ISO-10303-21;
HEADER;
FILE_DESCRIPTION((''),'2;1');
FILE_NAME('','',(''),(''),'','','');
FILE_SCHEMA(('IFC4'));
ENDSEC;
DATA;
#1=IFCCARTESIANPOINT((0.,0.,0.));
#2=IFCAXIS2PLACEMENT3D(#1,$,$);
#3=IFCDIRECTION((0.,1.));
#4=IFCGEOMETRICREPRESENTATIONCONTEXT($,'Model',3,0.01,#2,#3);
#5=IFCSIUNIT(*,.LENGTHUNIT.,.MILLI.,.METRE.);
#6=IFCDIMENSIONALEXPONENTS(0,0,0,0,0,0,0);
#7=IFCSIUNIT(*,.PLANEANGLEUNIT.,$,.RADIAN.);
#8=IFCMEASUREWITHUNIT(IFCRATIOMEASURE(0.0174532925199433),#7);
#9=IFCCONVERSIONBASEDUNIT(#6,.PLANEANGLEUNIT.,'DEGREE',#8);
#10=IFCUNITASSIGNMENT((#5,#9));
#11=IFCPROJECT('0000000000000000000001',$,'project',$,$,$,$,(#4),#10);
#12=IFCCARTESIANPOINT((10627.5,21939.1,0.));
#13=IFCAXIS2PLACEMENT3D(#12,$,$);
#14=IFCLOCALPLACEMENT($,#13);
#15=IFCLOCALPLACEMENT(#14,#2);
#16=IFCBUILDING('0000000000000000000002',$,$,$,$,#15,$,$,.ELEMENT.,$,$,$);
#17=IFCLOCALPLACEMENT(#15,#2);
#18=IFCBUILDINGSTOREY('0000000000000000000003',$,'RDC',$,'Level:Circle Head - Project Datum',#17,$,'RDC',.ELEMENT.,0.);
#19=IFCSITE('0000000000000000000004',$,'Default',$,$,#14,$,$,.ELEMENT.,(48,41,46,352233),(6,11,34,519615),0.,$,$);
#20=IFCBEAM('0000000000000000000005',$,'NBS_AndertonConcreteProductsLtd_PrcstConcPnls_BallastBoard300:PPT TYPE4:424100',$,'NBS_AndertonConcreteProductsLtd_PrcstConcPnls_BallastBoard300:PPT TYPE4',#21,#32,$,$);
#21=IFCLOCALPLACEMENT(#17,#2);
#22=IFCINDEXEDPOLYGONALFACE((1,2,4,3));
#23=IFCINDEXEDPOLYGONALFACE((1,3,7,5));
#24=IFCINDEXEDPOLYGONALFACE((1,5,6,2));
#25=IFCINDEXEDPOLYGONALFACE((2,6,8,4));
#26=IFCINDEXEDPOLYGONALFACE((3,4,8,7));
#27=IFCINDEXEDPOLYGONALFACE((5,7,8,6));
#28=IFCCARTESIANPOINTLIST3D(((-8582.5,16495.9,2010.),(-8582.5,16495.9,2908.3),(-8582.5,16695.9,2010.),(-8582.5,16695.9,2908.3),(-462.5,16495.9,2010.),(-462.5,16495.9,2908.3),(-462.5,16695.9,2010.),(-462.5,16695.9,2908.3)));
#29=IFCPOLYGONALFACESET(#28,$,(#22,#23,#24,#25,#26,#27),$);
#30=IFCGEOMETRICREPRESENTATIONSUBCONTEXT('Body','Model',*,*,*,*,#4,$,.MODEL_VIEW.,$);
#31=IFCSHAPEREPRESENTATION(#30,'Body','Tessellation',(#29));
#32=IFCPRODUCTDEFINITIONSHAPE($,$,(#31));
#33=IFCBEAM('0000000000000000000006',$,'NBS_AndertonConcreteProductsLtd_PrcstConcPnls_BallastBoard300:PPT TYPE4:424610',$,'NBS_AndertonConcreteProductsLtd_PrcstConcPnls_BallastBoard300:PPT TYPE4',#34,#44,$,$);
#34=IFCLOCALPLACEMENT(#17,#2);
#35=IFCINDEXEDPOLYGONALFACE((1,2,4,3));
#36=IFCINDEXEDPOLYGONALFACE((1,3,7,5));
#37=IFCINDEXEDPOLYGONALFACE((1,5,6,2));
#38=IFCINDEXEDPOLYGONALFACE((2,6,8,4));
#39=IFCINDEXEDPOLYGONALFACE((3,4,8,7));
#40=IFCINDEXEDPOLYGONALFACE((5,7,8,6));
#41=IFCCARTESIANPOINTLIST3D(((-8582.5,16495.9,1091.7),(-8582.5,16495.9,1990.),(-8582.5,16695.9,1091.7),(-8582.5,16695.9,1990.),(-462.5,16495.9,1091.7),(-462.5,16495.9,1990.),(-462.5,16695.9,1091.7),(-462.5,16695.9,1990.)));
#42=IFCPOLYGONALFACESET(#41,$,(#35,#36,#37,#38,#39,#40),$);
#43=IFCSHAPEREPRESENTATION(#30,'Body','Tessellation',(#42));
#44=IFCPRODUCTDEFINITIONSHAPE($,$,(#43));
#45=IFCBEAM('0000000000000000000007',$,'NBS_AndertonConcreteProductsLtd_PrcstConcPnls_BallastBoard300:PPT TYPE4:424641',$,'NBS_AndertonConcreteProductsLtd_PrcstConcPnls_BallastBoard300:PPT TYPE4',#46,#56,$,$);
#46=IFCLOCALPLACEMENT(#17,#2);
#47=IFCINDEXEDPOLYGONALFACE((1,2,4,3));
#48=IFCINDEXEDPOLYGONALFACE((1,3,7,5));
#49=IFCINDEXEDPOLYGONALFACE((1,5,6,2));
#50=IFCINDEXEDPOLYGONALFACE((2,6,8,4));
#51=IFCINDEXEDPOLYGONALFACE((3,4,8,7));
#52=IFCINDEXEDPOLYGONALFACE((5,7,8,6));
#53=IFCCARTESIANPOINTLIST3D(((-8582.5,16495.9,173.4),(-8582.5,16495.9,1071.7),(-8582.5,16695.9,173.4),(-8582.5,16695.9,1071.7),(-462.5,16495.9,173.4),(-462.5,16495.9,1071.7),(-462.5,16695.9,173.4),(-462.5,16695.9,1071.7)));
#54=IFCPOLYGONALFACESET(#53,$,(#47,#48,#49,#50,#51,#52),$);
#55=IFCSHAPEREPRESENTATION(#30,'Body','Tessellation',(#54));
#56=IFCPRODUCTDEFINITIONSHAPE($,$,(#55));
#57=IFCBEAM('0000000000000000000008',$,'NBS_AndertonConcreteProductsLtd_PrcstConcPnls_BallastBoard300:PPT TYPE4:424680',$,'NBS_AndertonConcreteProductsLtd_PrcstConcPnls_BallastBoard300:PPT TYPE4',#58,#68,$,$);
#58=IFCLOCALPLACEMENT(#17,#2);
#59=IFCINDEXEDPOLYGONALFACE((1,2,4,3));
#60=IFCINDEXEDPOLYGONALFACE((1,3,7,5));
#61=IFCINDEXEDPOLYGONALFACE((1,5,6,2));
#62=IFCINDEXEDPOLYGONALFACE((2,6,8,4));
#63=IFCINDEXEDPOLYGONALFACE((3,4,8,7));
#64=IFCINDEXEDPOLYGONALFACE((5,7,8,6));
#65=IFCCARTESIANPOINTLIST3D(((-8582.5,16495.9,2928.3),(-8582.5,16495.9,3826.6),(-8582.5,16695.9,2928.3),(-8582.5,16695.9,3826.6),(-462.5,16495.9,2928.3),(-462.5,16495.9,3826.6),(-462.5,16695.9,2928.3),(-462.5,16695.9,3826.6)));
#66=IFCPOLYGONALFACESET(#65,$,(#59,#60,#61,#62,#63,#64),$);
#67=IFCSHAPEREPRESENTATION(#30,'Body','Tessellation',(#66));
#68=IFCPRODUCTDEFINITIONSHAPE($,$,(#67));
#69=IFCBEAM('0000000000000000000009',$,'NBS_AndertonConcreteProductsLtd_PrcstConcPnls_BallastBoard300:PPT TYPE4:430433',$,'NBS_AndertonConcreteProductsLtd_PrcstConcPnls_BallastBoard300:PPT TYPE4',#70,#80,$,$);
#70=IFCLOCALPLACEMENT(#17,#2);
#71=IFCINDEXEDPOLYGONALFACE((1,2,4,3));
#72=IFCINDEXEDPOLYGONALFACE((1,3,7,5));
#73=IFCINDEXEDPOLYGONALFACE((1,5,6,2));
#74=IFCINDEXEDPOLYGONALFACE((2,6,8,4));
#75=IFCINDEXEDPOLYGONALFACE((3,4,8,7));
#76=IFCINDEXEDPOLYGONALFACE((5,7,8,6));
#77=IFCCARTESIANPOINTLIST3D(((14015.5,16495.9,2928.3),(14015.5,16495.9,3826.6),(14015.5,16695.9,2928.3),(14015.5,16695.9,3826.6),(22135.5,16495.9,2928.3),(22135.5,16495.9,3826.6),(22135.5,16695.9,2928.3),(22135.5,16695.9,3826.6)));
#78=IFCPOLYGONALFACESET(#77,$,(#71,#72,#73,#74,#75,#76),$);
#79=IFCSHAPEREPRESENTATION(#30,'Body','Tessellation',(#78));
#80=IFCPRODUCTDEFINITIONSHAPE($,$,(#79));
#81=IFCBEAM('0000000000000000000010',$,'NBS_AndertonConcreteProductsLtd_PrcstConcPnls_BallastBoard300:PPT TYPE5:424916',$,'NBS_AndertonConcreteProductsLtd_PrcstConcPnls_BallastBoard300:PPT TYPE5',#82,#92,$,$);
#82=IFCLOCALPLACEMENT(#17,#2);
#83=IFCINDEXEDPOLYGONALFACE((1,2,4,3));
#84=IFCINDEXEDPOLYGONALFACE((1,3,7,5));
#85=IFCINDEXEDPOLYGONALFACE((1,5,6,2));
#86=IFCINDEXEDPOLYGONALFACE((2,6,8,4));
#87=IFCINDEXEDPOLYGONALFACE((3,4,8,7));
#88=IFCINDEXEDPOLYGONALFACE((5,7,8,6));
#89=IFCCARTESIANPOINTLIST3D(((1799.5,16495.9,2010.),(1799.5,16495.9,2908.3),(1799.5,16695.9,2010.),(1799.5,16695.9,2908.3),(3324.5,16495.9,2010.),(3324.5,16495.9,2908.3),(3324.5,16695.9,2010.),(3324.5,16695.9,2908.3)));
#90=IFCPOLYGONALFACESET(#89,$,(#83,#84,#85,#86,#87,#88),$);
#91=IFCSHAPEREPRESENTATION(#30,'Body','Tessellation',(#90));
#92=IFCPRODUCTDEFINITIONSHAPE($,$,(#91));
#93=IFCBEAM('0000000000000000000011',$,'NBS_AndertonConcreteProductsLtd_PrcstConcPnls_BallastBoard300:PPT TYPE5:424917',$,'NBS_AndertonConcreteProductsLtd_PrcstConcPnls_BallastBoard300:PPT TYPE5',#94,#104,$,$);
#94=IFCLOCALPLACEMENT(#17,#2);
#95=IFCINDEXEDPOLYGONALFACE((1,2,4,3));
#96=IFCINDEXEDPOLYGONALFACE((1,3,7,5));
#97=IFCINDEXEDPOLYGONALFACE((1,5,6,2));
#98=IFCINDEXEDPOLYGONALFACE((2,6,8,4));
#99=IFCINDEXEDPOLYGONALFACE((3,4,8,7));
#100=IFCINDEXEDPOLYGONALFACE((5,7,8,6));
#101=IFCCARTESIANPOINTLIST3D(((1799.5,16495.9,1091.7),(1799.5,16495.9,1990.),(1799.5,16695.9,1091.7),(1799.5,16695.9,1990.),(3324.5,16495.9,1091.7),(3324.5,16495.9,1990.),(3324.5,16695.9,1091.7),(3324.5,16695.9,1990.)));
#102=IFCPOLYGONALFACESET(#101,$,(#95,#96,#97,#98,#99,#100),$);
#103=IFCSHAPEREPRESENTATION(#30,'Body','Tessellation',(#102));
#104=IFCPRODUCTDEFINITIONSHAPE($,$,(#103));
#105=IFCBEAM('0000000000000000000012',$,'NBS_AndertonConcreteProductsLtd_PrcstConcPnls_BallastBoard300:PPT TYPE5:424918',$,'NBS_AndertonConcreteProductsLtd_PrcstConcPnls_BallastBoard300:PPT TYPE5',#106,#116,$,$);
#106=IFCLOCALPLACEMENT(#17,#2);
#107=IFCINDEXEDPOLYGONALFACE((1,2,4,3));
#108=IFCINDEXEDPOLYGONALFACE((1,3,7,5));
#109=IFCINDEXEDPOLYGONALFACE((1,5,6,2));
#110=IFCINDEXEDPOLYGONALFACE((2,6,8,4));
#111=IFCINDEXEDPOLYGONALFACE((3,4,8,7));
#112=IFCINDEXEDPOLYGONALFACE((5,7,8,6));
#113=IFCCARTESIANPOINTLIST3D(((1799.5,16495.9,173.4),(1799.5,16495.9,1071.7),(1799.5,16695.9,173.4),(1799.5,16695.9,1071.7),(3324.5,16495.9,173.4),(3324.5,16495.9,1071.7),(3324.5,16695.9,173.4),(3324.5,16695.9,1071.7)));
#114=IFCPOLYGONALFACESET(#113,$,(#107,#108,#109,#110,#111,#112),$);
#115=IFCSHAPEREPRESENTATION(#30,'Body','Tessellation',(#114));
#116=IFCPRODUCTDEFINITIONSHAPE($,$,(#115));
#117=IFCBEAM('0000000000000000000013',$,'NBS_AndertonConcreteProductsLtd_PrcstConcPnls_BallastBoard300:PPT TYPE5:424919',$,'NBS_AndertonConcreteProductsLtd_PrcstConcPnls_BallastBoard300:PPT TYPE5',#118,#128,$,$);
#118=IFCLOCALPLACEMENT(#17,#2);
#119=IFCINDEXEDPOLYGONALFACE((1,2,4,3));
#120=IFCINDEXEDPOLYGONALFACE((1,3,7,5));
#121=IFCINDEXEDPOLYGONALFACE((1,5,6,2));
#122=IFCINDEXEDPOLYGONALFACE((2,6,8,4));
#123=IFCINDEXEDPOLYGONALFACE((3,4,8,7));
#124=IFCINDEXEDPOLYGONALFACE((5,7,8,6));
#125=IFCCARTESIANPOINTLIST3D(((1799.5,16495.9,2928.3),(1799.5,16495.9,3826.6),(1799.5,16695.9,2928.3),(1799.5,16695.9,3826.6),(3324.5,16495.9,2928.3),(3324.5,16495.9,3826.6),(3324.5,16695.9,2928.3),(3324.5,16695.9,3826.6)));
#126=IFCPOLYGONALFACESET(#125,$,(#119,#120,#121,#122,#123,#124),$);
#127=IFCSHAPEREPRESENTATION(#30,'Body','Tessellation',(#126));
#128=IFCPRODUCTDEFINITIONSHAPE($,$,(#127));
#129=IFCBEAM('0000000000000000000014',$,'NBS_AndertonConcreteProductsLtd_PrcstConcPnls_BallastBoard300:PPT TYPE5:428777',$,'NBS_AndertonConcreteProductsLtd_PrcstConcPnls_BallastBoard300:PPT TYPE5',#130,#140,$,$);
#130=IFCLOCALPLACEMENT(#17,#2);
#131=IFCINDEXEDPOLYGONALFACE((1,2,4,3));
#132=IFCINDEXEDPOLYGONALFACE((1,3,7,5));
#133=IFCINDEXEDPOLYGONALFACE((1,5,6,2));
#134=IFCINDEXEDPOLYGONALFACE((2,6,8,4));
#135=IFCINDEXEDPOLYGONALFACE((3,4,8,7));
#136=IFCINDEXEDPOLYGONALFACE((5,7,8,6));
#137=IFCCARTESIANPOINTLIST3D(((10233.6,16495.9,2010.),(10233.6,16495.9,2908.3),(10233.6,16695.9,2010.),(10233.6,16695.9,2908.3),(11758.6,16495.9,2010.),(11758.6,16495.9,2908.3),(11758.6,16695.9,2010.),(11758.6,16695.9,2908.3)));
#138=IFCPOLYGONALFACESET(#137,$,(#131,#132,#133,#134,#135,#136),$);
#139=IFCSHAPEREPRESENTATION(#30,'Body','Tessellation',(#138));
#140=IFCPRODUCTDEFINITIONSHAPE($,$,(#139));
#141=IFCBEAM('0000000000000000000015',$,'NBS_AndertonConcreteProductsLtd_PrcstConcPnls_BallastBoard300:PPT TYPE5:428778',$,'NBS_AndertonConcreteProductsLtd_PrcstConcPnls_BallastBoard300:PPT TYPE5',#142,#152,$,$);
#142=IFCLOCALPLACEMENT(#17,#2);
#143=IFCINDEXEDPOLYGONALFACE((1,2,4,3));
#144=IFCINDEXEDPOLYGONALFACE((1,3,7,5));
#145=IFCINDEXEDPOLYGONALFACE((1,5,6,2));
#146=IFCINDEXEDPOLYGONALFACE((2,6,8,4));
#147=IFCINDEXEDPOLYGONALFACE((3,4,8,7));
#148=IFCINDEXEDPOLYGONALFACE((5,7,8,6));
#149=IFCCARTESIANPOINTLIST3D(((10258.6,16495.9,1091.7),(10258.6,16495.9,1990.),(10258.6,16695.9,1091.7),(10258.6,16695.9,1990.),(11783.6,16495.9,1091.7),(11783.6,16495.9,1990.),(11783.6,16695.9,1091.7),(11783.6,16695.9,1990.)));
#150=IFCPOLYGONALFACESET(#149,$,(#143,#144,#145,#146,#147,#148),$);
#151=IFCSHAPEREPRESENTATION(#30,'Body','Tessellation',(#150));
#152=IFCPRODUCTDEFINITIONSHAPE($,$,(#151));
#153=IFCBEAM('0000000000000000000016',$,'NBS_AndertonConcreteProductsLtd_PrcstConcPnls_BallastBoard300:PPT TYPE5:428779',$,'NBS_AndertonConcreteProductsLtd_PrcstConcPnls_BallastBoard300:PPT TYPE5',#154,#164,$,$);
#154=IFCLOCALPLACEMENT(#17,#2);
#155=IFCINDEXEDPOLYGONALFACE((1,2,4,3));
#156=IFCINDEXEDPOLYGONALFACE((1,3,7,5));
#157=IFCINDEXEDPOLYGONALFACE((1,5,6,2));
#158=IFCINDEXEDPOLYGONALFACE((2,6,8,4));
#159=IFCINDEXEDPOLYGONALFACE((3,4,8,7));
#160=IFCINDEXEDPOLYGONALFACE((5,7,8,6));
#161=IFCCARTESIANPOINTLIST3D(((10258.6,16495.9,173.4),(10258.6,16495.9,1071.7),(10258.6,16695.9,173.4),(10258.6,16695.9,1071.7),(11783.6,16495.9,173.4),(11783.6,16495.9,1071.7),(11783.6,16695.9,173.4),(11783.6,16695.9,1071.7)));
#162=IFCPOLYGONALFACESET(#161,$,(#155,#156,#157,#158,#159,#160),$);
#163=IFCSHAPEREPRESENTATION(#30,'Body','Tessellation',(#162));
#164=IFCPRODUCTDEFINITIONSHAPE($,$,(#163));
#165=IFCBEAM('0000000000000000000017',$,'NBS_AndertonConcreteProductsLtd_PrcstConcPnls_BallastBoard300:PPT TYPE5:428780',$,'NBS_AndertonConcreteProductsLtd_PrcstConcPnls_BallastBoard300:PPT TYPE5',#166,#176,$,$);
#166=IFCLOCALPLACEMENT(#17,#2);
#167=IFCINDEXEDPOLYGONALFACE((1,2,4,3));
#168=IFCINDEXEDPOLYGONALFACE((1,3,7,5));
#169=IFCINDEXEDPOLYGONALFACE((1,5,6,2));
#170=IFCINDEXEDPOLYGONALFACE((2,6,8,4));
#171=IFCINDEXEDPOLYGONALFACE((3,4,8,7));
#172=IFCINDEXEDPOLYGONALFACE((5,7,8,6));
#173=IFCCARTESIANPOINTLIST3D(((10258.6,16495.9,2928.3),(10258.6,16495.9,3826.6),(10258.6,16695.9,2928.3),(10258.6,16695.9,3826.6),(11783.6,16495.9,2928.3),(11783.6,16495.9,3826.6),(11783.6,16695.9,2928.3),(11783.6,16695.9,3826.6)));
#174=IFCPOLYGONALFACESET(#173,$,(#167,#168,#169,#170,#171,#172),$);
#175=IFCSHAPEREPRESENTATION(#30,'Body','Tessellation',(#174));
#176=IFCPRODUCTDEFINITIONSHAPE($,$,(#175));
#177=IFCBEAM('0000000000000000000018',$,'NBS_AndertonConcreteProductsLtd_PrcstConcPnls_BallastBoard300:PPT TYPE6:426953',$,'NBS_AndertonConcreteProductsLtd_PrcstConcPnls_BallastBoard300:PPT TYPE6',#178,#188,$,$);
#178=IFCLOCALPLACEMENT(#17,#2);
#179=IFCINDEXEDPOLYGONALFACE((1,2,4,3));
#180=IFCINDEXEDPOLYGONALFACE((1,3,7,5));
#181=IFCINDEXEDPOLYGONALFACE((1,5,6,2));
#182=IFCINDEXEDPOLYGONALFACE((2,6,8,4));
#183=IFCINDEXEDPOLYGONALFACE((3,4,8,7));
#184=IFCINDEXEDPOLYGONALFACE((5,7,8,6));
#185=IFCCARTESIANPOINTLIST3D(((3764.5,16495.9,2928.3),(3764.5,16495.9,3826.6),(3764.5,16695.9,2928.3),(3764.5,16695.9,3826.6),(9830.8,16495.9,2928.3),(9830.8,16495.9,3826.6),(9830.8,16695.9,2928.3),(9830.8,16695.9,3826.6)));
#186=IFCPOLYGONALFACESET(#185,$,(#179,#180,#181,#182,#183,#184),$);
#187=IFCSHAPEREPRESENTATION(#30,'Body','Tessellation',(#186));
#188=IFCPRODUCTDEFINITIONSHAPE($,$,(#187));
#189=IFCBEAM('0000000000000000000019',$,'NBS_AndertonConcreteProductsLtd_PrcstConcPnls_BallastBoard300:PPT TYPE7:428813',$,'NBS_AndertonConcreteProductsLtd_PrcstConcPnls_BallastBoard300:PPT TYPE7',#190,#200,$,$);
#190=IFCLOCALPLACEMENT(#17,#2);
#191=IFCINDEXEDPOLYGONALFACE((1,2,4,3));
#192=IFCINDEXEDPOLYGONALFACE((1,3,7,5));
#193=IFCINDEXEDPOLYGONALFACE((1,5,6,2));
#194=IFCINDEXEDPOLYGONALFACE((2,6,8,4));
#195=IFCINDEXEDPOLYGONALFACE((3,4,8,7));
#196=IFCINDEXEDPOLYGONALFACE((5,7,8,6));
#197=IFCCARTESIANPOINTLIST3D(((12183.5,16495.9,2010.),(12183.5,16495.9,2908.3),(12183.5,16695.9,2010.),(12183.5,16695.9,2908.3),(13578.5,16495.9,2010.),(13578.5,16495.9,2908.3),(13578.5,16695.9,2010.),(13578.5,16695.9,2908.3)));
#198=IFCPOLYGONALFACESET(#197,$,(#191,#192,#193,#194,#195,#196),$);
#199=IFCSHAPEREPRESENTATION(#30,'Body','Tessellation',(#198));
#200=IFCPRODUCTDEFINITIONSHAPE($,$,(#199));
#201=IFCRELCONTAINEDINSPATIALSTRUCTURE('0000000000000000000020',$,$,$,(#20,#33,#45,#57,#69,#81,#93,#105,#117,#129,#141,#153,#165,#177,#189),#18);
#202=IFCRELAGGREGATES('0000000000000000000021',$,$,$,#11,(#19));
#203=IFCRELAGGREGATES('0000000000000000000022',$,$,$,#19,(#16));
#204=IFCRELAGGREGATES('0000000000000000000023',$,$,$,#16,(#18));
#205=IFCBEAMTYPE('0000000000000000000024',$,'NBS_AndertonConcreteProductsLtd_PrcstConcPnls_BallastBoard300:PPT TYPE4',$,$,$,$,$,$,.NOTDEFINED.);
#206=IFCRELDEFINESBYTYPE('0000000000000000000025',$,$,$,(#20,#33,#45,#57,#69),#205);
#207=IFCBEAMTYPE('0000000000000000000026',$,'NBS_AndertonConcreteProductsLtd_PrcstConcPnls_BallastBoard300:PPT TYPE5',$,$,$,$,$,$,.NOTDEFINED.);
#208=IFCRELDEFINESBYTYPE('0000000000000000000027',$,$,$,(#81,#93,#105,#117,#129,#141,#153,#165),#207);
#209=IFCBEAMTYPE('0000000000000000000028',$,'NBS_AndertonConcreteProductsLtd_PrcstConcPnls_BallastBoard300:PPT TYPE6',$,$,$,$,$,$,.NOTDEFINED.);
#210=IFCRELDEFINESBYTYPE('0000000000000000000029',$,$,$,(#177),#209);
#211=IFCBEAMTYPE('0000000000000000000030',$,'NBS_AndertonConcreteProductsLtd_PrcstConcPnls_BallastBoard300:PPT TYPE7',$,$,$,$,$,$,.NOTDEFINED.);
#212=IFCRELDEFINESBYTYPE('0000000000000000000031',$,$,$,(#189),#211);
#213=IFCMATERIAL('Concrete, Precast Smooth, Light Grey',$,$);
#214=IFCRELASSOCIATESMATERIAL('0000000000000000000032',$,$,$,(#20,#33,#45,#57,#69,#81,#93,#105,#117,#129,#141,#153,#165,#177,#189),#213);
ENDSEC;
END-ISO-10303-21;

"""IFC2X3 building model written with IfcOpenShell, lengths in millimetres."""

from ifc_helpers import new_model, entity, si_unit, converted_unit, direction, frame, frame_2d, origin, place, context, subcontext, project, spatial, rectangle, extrude, material, type_object, element, save


model = new_model("IFC2X3")

# Units and contexts
model_context = context("Model", 3, precision=0.01, world=origin(), true_north=direction((0.0, 1.0)))
body_context = subcontext(model_context, "Body", "Model", "MODEL_VIEW")
ifc_project = project(units=[si_unit("LENGTHUNIT", "METRE", prefix="MILLI"), converted_unit("PLANEANGLEUNIT", "DEGREE", entity("IfcRatioMeasure", 0.0174532925199433), si_unit("PLANEANGLEUNIT", "RADIAN"), dimensions=[0, 0, 0, 0, 0, 0, 0])], contexts=[model_context])

# Site, building, storey
site_placement = place(None, frame((10627.5, 21939.1, 0.0)))
site = spatial("IfcSite", under=ifc_project, at=site_placement, Name="Default", CompositionType="ELEMENT", RefLatitude=(48, 41, 46, 352233), RefLongitude=(6, 11, 34, 519615), RefElevation=0.0)
building_placement = place(site_placement, origin())
building = spatial("IfcBuilding", under=site, at=building_placement, CompositionType="ELEMENT")
storey_placement = place(building_placement, origin())
storey = spatial("IfcBuildingStorey", under=building, at=storey_placement, Name="RDC", ObjectType="Level:Circle Head - Project Datum", LongName="RDC", CompositionType="ELEMENT", Elevation=0.0)

# Beams
ifc_material_1 = material(Name="Concrete, Precast Smooth, Light Grey")
beam_type_1 = type_object("IfcBeamType", Name="NBS_AndertonConcreteProductsLtd_PrcstConcPnls_BallastBoard300:PPT TYPE4", PredefinedType="NOTDEFINED")
beam_1_placement = place(storey_placement, origin())
element("IfcBeam", 1, at=beam_1_placement, inside=storey, type_object=beam_type_1, material=ifc_material_1, Name="NBS_AndertonConcreteProductsLtd_PrcstConcPnls_BallastBoard300:PPT TYPE4:424100", ObjectType="NBS_AndertonConcreteProductsLtd_PrcstConcPnls_BallastBoard300:PPT TYPE4", context=body_context, shape_type="SweptSolid", body=[
    extrude(rectangle(XDim=898.3, YDim=200.0, at=frame_2d((0.0, 0.0), x_axis=(0.0, 1.0))), frame((-8582.5, 16595.9, 2459.2), z_axis=(1.0, 0.0, 0.0), x_axis=(0.0, 1.0, 0.0)), (0.0, 0.0, 1.0), 8120.0),
])
beam_2_placement = place(storey_placement, origin())
element("IfcBeam", 2, at=beam_2_placement, inside=storey, type_object=beam_type_1, material=ifc_material_1, Name="NBS_AndertonConcreteProductsLtd_PrcstConcPnls_BallastBoard300:PPT TYPE4:424610", ObjectType="NBS_AndertonConcreteProductsLtd_PrcstConcPnls_BallastBoard300:PPT TYPE4", context=body_context, shape_type="SweptSolid", body=[
    extrude(rectangle(XDim=898.3, YDim=200.0, at=frame_2d((0.0, 0.0), x_axis=(0.0, 1.0))), frame((-8582.5, 16595.9, 1540.8), z_axis=(1.0, 0.0, 0.0), x_axis=(0.0, 1.0, 0.0)), (0.0, 0.0, 1.0), 8120.0),
])
beam_3_placement = place(storey_placement, origin())
element("IfcBeam", 3, at=beam_3_placement, inside=storey, type_object=beam_type_1, material=ifc_material_1, Name="NBS_AndertonConcreteProductsLtd_PrcstConcPnls_BallastBoard300:PPT TYPE4:424641", ObjectType="NBS_AndertonConcreteProductsLtd_PrcstConcPnls_BallastBoard300:PPT TYPE4", context=body_context, shape_type="SweptSolid", body=[
    extrude(rectangle(XDim=898.3, YDim=200.0, at=frame_2d((0.0, 0.0), x_axis=(0.0, 1.0))), frame((-8582.5, 16595.9, 622.5), z_axis=(1.0, 0.0, 0.0), x_axis=(0.0, 1.0, 0.0)), (0.0, 0.0, 1.0), 8120.0),
])
beam_4_placement = place(storey_placement, origin())
element("IfcBeam", 4, at=beam_4_placement, inside=storey, type_object=beam_type_1, material=ifc_material_1, Name="NBS_AndertonConcreteProductsLtd_PrcstConcPnls_BallastBoard300:PPT TYPE4:424680", ObjectType="NBS_AndertonConcreteProductsLtd_PrcstConcPnls_BallastBoard300:PPT TYPE4", context=body_context, shape_type="SweptSolid", body=[
    extrude(rectangle(XDim=898.3, YDim=200.0, at=frame_2d((0.0, 0.0), x_axis=(0.0, 1.0))), frame((-8582.5, 16595.9, 3377.5), z_axis=(1.0, 0.0, 0.0), x_axis=(0.0, 1.0, 0.0)), (0.0, 0.0, 1.0), 8120.0),
])
beam_5_placement = place(storey_placement, origin())
element("IfcBeam", 5, at=beam_5_placement, inside=storey, type_object=beam_type_1, material=ifc_material_1, Name="NBS_AndertonConcreteProductsLtd_PrcstConcPnls_BallastBoard300:PPT TYPE4:430433", ObjectType="NBS_AndertonConcreteProductsLtd_PrcstConcPnls_BallastBoard300:PPT TYPE4", context=body_context, shape_type="SweptSolid", body=[
    extrude(rectangle(XDim=898.3, YDim=200.0, at=frame_2d((0.0, 0.0), x_axis=(0.0, 1.0))), frame((14015.5, 16595.9, 3377.5), z_axis=(1.0, 0.0, 0.0), x_axis=(0.0, 1.0, 0.0)), (0.0, 0.0, 1.0), 8120.0),
])
beam_type_2 = type_object("IfcBeamType", Name="NBS_AndertonConcreteProductsLtd_PrcstConcPnls_BallastBoard300:PPT TYPE5", PredefinedType="NOTDEFINED")
beam_6_placement = place(storey_placement, origin())
element("IfcBeam", 6, at=beam_6_placement, inside=storey, type_object=beam_type_2, material=ifc_material_1, Name="NBS_AndertonConcreteProductsLtd_PrcstConcPnls_BallastBoard300:PPT TYPE5:424916", ObjectType="NBS_AndertonConcreteProductsLtd_PrcstConcPnls_BallastBoard300:PPT TYPE5", context=body_context, shape_type="SweptSolid", body=[
    extrude(rectangle(XDim=898.3, YDim=200.0, at=frame_2d((0.0, 0.0), x_axis=(0.0, 1.0))), frame((1799.5, 16595.9, 2459.2), z_axis=(1.0, 0.0, 0.0), x_axis=(0.0, 1.0, 0.0)), (0.0, 0.0, 1.0), 1525.0),
])
beam_7_placement = place(storey_placement, origin())
element("IfcBeam", 7, at=beam_7_placement, inside=storey, type_object=beam_type_2, material=ifc_material_1, Name="NBS_AndertonConcreteProductsLtd_PrcstConcPnls_BallastBoard300:PPT TYPE5:424917", ObjectType="NBS_AndertonConcreteProductsLtd_PrcstConcPnls_BallastBoard300:PPT TYPE5", context=body_context, shape_type="SweptSolid", body=[
    extrude(rectangle(XDim=898.3, YDim=200.0, at=frame_2d((0.0, 0.0), x_axis=(0.0, 1.0))), frame((1799.5, 16595.9, 1540.8), z_axis=(1.0, 0.0, 0.0), x_axis=(0.0, 1.0, 0.0)), (0.0, 0.0, 1.0), 1525.0),
])
beam_8_placement = place(storey_placement, origin())
element("IfcBeam", 8, at=beam_8_placement, inside=storey, type_object=beam_type_2, material=ifc_material_1, Name="NBS_AndertonConcreteProductsLtd_PrcstConcPnls_BallastBoard300:PPT TYPE5:424918", ObjectType="NBS_AndertonConcreteProductsLtd_PrcstConcPnls_BallastBoard300:PPT TYPE5", context=body_context, shape_type="SweptSolid", body=[
    extrude(rectangle(XDim=898.3, YDim=200.0, at=frame_2d((0.0, 0.0), x_axis=(0.0, 1.0))), frame((1799.5, 16595.9, 622.5), z_axis=(1.0, 0.0, 0.0), x_axis=(0.0, 1.0, 0.0)), (0.0, 0.0, 1.0), 1525.0),
])
beam_9_placement = place(storey_placement, origin())
element("IfcBeam", 9, at=beam_9_placement, inside=storey, type_object=beam_type_2, material=ifc_material_1, Name="NBS_AndertonConcreteProductsLtd_PrcstConcPnls_BallastBoard300:PPT TYPE5:424919", ObjectType="NBS_AndertonConcreteProductsLtd_PrcstConcPnls_BallastBoard300:PPT TYPE5", context=body_context, shape_type="SweptSolid", body=[
    extrude(rectangle(XDim=898.3, YDim=200.0, at=frame_2d((0.0, 0.0), x_axis=(0.0, 1.0))), frame((1799.5, 16595.9, 3377.5), z_axis=(1.0, 0.0, 0.0), x_axis=(0.0, 1.0, 0.0)), (0.0, 0.0, 1.0), 1525.0),
])
beam_10_placement = place(storey_placement, origin())
element("IfcBeam", 10, at=beam_10_placement, inside=storey, type_object=beam_type_2, material=ifc_material_1, Name="NBS_AndertonConcreteProductsLtd_PrcstConcPnls_BallastBoard300:PPT TYPE5:428777", ObjectType="NBS_AndertonConcreteProductsLtd_PrcstConcPnls_BallastBoard300:PPT TYPE5", context=body_context, shape_type="SweptSolid", body=[
    extrude(rectangle(XDim=898.3, YDim=200.0, at=frame_2d((0.0, 0.0), x_axis=(0.0, 1.0))), frame((10233.6, 16595.9, 2459.2), z_axis=(1.0, 0.0, 0.0), x_axis=(0.0, 1.0, 0.0)), (0.0, 0.0, 1.0), 1525.0),
])
beam_11_placement = place(storey_placement, origin())
element("IfcBeam", 11, at=beam_11_placement, inside=storey, type_object=beam_type_2, material=ifc_material_1, Name="NBS_AndertonConcreteProductsLtd_PrcstConcPnls_BallastBoard300:PPT TYPE5:428778", ObjectType="NBS_AndertonConcreteProductsLtd_PrcstConcPnls_BallastBoard300:PPT TYPE5", context=body_context, shape_type="SweptSolid", body=[
    extrude(rectangle(XDim=898.3, YDim=200.0, at=frame_2d((0.0, 0.0), x_axis=(0.0, 1.0))), frame((10258.6, 16595.9, 1540.8), z_axis=(1.0, 0.0, 0.0), x_axis=(0.0, 1.0, 0.0)), (0.0, 0.0, 1.0), 1525.0),
])
beam_12_placement = place(storey_placement, origin())
element("IfcBeam", 12, at=beam_12_placement, inside=storey, type_object=beam_type_2, material=ifc_material_1, Name="NBS_AndertonConcreteProductsLtd_PrcstConcPnls_BallastBoard300:PPT TYPE5:428779", ObjectType="NBS_AndertonConcreteProductsLtd_PrcstConcPnls_BallastBoard300:PPT TYPE5", context=body_context, shape_type="SweptSolid", body=[
    extrude(rectangle(XDim=898.3, YDim=200.0, at=frame_2d((0.0, 0.0), x_axis=(0.0, 1.0))), frame((10258.6, 16595.9, 622.5), z_axis=(1.0, 0.0, 0.0), x_axis=(0.0, 1.0, 0.0)), (0.0, 0.0, 1.0), 1525.0),
])
beam_13_placement = place(storey_placement, origin())
element("IfcBeam", 13, at=beam_13_placement, inside=storey, type_object=beam_type_2, material=ifc_material_1, Name="NBS_AndertonConcreteProductsLtd_PrcstConcPnls_BallastBoard300:PPT TYPE5:428780", ObjectType="NBS_AndertonConcreteProductsLtd_PrcstConcPnls_BallastBoard300:PPT TYPE5", context=body_context, shape_type="SweptSolid", body=[
    extrude(rectangle(XDim=898.3, YDim=200.0, at=frame_2d((0.0, 0.0), x_axis=(0.0, 1.0))), frame((10258.6, 16595.9, 3377.5), z_axis=(1.0, 0.0, 0.0), x_axis=(0.0, 1.0, 0.0)), (0.0, 0.0, 1.0), 1525.0),
])
beam_type_3 = type_object("IfcBeamType", Name="NBS_AndertonConcreteProductsLtd_PrcstConcPnls_BallastBoard300:PPT TYPE6", PredefinedType="NOTDEFINED")
beam_14_placement = place(storey_placement, origin())
element("IfcBeam", 14, at=beam_14_placement, inside=storey, type_object=beam_type_3, material=ifc_material_1, Name="NBS_AndertonConcreteProductsLtd_PrcstConcPnls_BallastBoard300:PPT TYPE6:426953", ObjectType="NBS_AndertonConcreteProductsLtd_PrcstConcPnls_BallastBoard300:PPT TYPE6", context=body_context, shape_type="SweptSolid", body=[
    extrude(rectangle(XDim=898.3, YDim=200.0, at=frame_2d((0.0, 0.0), x_axis=(0.0, 1.0))), frame((3764.5, 16595.9, 3377.5), z_axis=(1.0, 0.0, 0.0), x_axis=(0.0, 1.0, 0.0)), (0.0, 0.0, 1.0), 6066.3),
])
beam_type_4 = type_object("IfcBeamType", Name="NBS_AndertonConcreteProductsLtd_PrcstConcPnls_BallastBoard300:PPT TYPE7", PredefinedType="NOTDEFINED")
beam_15_placement = place(storey_placement, origin())
element("IfcBeam", 15, at=beam_15_placement, inside=storey, type_object=beam_type_4, material=ifc_material_1, Name="NBS_AndertonConcreteProductsLtd_PrcstConcPnls_BallastBoard300:PPT TYPE7:428813", ObjectType="NBS_AndertonConcreteProductsLtd_PrcstConcPnls_BallastBoard300:PPT TYPE7", context=body_context, shape_type="SweptSolid", body=[
    extrude(rectangle(XDim=898.3, YDim=200.0, at=frame_2d((0.0, 0.0), x_axis=(0.0, 1.0))), frame((12183.5, 16595.9, 2459.2), z_axis=(1.0, 0.0, 0.0), x_axis=(0.0, 1.0, 0.0)), (0.0, 0.0, 1.0), 1395.0),
])

save(model, "model.ifc")
